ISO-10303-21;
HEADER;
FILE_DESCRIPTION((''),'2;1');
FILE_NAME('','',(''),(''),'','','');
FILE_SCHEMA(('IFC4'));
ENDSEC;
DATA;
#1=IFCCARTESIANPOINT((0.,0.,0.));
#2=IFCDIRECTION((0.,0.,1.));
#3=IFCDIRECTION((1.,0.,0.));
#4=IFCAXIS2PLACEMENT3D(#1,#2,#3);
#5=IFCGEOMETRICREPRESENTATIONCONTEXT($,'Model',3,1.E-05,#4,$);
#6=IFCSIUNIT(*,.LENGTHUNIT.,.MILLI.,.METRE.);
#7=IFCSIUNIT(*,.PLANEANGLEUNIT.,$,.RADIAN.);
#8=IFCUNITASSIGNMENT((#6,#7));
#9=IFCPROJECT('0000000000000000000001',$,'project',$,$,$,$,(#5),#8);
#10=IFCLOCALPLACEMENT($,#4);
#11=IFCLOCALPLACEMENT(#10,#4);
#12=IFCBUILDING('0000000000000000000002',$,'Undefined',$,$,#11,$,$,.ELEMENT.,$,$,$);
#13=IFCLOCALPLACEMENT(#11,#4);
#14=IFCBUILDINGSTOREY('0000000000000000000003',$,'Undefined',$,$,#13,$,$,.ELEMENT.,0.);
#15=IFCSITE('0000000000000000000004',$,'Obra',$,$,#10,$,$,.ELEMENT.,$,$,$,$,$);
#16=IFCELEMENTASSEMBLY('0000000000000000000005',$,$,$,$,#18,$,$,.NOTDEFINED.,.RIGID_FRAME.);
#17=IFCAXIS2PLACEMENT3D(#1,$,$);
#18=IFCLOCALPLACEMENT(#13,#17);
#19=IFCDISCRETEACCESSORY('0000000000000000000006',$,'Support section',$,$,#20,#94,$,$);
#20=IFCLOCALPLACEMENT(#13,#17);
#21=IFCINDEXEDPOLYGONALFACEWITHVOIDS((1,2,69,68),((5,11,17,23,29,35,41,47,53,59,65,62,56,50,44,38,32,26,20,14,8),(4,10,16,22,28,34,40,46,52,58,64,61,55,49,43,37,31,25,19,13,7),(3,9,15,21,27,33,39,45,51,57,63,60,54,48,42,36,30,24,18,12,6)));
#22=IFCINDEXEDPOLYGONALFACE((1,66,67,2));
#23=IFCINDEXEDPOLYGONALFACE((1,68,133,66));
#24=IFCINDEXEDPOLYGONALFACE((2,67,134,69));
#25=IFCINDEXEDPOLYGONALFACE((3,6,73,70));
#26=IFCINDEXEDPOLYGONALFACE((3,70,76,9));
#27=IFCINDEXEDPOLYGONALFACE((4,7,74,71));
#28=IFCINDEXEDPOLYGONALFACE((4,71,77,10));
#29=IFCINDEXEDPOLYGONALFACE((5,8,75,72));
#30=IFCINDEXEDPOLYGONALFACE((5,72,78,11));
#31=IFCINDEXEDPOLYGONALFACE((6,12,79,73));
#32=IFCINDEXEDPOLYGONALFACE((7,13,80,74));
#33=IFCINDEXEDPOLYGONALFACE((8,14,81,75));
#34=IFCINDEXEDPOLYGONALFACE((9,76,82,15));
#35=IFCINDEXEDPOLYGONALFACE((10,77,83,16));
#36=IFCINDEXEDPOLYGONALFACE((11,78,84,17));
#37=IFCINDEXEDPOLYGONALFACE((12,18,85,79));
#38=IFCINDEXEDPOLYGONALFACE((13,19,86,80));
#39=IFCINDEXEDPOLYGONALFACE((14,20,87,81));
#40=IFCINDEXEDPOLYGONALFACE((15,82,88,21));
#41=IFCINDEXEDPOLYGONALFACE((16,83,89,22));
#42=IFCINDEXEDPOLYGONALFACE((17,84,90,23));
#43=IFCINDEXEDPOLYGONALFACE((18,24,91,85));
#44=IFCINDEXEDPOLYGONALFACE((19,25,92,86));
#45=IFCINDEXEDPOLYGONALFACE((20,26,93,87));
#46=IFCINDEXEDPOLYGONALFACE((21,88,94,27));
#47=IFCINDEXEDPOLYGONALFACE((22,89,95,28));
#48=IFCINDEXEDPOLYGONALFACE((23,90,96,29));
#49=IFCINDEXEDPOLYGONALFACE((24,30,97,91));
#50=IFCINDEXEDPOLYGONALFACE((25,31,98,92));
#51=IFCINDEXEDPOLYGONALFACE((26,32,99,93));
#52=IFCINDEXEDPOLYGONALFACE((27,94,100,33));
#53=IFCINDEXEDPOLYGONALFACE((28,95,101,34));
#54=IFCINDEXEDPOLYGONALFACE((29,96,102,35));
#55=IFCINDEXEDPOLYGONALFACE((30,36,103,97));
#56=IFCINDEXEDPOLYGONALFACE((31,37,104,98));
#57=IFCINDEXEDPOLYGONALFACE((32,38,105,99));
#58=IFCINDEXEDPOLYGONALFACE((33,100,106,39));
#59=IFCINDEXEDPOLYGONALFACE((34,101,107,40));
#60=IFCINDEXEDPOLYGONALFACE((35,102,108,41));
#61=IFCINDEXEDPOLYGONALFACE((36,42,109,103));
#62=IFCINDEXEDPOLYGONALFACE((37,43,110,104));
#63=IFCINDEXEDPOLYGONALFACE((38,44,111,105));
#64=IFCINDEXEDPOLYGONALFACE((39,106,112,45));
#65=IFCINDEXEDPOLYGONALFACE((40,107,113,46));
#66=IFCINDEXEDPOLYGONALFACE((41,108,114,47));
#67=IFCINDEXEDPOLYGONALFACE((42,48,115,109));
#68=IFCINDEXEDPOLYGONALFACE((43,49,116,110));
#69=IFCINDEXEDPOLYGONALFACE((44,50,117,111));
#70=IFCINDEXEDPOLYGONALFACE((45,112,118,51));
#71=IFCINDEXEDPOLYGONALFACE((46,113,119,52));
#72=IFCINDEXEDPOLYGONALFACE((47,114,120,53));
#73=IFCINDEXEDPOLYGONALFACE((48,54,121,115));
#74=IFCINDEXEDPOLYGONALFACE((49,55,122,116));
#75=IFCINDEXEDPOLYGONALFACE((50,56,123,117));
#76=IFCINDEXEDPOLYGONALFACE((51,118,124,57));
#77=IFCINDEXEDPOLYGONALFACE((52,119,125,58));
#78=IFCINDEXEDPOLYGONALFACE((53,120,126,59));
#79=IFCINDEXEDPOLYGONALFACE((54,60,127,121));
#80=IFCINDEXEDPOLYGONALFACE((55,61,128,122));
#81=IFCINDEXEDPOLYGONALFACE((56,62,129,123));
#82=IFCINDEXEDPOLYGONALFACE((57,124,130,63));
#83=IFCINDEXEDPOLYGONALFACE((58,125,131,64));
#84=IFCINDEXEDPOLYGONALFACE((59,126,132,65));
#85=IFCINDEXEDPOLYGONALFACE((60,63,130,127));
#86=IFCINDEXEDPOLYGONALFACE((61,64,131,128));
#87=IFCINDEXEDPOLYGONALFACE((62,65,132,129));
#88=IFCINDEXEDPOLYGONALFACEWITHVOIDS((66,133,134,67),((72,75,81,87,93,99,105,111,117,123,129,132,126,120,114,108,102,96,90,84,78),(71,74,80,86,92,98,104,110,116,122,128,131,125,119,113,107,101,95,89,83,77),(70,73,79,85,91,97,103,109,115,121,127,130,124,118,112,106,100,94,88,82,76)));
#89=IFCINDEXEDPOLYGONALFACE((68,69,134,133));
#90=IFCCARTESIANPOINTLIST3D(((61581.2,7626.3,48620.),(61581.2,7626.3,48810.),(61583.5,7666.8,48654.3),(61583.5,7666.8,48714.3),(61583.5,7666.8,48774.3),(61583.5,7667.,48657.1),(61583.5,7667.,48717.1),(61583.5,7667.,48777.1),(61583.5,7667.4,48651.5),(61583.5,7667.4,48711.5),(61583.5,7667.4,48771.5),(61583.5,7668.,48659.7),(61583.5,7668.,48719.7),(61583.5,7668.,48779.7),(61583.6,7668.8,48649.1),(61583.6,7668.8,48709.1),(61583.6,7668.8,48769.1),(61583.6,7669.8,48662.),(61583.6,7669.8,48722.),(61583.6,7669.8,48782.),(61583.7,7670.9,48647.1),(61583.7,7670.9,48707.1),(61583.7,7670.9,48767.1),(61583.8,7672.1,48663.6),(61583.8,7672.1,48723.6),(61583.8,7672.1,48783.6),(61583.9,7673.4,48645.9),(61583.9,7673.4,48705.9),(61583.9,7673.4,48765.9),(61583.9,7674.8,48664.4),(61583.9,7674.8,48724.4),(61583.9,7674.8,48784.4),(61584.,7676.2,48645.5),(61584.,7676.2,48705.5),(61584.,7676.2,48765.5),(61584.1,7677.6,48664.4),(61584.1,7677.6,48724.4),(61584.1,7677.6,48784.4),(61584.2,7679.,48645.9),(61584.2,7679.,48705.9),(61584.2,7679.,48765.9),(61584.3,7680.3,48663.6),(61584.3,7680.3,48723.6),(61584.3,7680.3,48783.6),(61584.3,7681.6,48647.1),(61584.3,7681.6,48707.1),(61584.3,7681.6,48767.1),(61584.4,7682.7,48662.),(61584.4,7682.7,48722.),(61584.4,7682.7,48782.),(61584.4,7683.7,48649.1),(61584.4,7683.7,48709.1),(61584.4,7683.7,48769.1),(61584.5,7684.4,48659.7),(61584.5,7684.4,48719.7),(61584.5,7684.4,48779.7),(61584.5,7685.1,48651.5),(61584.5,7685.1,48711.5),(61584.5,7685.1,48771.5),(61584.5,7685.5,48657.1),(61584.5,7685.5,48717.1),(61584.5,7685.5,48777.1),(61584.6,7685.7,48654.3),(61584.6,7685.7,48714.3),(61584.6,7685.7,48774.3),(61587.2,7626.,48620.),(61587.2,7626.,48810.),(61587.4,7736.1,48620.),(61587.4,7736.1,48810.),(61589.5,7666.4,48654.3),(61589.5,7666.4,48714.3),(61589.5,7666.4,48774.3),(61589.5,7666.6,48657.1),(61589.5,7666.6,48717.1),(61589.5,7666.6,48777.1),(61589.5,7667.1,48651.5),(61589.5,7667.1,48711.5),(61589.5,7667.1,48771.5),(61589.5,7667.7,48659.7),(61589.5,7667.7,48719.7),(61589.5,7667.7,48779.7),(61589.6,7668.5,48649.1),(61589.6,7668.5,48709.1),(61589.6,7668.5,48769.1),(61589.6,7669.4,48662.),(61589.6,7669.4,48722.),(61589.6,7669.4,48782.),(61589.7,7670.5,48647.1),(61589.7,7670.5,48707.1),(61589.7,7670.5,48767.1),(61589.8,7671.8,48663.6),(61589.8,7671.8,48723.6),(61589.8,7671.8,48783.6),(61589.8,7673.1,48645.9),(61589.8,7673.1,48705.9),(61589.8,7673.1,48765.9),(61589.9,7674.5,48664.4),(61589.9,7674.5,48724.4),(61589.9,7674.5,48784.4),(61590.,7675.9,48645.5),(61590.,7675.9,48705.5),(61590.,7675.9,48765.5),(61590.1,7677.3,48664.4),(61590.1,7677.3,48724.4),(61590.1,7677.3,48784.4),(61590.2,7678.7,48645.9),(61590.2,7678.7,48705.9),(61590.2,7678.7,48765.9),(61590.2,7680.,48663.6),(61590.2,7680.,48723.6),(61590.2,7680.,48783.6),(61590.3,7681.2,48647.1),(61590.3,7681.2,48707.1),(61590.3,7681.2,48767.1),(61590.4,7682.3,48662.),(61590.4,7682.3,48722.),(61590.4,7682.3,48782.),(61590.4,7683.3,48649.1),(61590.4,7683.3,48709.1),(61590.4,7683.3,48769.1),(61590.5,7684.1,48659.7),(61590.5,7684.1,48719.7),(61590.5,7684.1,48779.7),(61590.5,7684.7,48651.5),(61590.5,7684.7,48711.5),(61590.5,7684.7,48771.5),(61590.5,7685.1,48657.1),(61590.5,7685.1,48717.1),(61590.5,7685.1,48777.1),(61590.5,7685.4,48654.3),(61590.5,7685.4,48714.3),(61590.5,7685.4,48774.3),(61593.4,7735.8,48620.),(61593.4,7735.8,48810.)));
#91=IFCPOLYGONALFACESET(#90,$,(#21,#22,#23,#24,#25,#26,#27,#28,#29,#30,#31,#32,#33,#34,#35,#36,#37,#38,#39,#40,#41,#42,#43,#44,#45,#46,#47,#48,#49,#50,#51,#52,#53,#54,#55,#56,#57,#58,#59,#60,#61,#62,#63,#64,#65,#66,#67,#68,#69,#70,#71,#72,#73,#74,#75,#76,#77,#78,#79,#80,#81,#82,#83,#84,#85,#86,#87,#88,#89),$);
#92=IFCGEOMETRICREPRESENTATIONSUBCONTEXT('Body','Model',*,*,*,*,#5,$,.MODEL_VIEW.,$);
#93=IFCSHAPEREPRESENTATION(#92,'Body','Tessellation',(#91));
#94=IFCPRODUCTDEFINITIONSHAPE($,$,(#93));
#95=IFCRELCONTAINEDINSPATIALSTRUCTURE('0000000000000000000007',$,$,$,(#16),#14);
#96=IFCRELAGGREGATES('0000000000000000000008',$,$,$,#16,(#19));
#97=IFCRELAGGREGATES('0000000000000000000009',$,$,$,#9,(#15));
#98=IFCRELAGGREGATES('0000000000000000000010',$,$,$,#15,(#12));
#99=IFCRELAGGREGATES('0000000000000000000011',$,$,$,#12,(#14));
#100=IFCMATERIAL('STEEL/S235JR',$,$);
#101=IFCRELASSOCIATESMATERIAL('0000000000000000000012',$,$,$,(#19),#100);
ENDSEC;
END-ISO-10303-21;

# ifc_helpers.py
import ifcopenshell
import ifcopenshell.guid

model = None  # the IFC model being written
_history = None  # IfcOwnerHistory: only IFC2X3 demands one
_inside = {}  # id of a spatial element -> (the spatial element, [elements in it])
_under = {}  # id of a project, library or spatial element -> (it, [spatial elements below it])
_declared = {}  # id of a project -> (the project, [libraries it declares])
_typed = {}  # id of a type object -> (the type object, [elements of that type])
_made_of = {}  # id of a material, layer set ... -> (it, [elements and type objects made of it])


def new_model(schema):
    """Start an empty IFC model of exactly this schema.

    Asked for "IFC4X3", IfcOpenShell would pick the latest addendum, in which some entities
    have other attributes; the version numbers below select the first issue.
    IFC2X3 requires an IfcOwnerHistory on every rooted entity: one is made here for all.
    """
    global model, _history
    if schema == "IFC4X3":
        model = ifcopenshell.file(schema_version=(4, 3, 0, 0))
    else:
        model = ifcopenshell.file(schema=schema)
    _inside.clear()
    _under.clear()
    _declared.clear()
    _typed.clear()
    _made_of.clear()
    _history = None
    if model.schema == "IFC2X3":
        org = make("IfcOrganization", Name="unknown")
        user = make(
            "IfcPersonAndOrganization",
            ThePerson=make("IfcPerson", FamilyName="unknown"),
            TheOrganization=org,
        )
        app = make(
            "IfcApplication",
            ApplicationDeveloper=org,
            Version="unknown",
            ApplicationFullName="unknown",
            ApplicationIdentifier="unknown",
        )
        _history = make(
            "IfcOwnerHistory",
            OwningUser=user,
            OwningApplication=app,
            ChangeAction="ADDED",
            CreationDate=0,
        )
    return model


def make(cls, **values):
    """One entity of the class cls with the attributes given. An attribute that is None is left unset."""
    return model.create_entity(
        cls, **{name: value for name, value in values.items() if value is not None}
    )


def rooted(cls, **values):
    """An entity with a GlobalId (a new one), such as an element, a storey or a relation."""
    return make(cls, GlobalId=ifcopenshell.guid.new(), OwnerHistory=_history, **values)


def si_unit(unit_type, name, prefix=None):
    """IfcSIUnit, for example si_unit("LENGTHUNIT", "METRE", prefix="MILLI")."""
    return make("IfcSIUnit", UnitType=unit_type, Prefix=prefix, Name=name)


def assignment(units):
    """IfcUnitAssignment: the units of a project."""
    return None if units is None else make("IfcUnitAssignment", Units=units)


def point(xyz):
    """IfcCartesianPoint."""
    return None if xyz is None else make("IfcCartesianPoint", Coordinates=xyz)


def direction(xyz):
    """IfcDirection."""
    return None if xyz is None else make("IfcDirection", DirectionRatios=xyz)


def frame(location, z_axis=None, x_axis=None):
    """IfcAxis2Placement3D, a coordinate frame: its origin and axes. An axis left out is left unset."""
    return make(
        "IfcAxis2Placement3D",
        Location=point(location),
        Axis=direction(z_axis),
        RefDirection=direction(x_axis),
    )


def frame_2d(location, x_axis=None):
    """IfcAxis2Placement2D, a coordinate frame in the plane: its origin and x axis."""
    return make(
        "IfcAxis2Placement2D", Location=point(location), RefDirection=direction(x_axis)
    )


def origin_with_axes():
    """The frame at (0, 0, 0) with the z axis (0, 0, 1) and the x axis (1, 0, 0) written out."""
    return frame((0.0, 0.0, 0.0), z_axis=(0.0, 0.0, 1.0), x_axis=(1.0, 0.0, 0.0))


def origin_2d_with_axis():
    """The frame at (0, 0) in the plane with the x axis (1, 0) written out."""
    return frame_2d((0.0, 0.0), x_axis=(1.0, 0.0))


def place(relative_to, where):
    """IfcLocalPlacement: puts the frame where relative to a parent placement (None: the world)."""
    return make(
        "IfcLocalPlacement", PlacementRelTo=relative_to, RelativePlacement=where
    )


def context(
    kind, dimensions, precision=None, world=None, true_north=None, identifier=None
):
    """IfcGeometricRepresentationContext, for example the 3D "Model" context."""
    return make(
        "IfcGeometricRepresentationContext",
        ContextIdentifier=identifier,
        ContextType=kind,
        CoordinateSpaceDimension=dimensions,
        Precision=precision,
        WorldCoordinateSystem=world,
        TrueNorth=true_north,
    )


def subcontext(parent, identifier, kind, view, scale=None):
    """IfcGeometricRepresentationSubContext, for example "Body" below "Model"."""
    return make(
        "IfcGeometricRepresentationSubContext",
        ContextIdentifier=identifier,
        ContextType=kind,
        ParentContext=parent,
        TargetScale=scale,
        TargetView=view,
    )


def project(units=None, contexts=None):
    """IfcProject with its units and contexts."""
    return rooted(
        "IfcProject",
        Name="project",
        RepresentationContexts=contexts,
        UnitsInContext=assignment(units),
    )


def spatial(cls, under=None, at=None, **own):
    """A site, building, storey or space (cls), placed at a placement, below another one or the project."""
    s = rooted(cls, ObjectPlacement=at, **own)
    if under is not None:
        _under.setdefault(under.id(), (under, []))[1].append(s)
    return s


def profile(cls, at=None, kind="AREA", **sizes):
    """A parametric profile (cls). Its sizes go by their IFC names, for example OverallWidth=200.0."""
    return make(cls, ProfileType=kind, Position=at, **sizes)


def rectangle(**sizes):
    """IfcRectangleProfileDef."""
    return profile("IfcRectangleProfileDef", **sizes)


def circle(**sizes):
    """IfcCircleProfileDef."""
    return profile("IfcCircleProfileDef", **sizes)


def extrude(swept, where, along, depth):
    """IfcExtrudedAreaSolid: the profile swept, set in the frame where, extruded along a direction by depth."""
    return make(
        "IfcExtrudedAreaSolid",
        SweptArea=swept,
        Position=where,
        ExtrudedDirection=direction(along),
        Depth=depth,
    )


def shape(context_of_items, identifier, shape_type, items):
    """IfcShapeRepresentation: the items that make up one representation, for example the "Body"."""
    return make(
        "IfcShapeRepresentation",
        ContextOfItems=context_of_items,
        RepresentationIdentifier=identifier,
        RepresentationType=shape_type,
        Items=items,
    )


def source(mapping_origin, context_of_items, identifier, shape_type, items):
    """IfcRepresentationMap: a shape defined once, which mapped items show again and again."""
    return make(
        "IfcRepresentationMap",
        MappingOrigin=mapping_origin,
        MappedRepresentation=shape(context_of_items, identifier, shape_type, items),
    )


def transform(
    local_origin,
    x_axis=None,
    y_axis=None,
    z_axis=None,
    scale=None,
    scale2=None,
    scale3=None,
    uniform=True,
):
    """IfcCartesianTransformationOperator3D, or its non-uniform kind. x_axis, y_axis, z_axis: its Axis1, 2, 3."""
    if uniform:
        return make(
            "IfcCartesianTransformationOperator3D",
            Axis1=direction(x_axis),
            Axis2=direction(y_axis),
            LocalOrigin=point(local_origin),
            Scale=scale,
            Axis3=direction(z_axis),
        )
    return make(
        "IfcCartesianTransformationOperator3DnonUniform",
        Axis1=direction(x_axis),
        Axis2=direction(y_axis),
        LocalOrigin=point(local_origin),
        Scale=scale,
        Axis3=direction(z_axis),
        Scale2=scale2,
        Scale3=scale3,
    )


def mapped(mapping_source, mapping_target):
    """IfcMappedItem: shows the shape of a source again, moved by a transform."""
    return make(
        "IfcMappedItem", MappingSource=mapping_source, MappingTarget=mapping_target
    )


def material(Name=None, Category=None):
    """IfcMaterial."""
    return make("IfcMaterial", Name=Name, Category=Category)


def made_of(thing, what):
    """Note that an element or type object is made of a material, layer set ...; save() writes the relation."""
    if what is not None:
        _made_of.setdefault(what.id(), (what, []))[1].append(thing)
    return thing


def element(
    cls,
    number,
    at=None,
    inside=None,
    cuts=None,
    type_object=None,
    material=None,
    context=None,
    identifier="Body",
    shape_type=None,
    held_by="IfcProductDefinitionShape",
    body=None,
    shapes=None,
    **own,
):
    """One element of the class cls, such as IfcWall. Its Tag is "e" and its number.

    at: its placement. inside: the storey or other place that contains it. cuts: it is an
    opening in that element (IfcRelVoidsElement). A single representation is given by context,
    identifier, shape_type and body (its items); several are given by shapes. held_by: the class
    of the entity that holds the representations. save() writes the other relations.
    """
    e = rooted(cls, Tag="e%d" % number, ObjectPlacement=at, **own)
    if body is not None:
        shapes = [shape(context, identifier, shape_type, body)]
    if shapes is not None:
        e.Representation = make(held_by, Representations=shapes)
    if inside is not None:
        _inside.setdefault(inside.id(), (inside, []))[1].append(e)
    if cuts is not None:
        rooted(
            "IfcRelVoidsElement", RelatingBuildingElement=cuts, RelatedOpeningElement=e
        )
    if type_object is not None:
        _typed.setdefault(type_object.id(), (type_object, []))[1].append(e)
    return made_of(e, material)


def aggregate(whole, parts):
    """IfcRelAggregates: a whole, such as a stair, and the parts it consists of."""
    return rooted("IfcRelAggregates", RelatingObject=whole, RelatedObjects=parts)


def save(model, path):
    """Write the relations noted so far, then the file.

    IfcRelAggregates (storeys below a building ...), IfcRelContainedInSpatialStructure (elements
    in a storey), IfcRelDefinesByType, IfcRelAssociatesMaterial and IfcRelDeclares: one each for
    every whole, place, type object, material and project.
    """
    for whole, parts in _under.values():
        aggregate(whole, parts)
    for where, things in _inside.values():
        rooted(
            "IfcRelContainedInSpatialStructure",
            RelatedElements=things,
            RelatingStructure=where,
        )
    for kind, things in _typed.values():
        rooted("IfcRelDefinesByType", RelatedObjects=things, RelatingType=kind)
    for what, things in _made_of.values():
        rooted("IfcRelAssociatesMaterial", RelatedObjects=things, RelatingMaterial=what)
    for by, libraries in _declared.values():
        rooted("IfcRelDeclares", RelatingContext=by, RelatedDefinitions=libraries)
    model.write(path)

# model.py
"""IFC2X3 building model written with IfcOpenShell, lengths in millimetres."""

from ifc_helpers import new_model, si_unit, frame, origin_with_axes, origin_2d_with_axis, place, context, subcontext, project, spatial, rectangle, circle, extrude, source, transform, mapped, material, element, aggregate, save


model = new_model("IFC2X3")

# Units and contexts
model_context = context("Model", 3, precision=1e-05, world=origin_with_axes())
body_context = subcontext(model_context, "Body", "Model", "MODEL_VIEW")
ifc_project = project(units=[si_unit("LENGTHUNIT", "METRE", prefix="MILLI"), si_unit("PLANEANGLEUNIT", "RADIAN")], contexts=[model_context])

# Site, building, storey
site_placement = place(None, origin_with_axes())
site = spatial("IfcSite", under=ifc_project, at=site_placement, Name="Obra", CompositionType="ELEMENT")
building_placement = place(site_placement, origin_with_axes())
building = spatial("IfcBuilding", under=site, at=building_placement, Name="Undefined", CompositionType="ELEMENT")
storey_placement = place(building_placement, origin_with_axes())
storey = spatial("IfcBuildingStorey", under=building, at=storey_placement, Name="Undefined", CompositionType="ELEMENT", Elevation=0.0)

# Element assembly
ifc_material_1 = material(Name="STEEL/S235JR")
assembly_1_placement = place(storey_placement, origin_with_axes())
assembly_1 = element("IfcElementAssembly", 1, at=assembly_1_placement, inside=storey, AssemblyPlace="NOTDEFINED", PredefinedType="RIGID_FRAME")

# Discrete accessory, opening
shared_shape_1 = source(origin_with_axes(), body_context, "Body", "SweptSolid", [
    extrude(circle(Radius=9.5, at=origin_2d_with_axis()), frame((0.0, -9.2, 0.0), z_axis=(0.0, 1.0, 0.0), x_axis=(1.0, 0.0, 0.0)), (0.0, 0.0, 1.0), 6.2),
])
discrete_accessory_1_placement = place(assembly_1_placement, frame((61587.3, 7681.1, 48620.0), z_axis=(0.0, 0.0, 1.0), x_axis=(0.05711, 0.998368, 0.0)))
discrete_accessory_1 = element("IfcDiscreteAccessory", 2, at=discrete_accessory_1_placement, material=ifc_material_1, Name="Support section", context=body_context, shape_type="SweptSolid", body=[
    extrude(rectangle(XDim=6.0, YDim=110.0, at=origin_2d_with_axis()), frame((0.0, 0.0, 190.0), z_axis=(0.0, 0.0, -1.0), x_axis=(0.0, 1.0, 0.0)), (0.0, 0.0, 1.0), 190.0),
])
opening_1_placement = place(assembly_1_placement, frame((61596.0, 7725.6, 48835.0), z_axis=(-0.05711, -0.998368, 0.0), x_axis=(0.0, 0.0, -1.0)))
element("IfcOpeningElement", 3, at=opening_1_placement, cuts=discrete_accessory_1, ObjectType="Opening", context=body_context, shape_type="MappedRepresentation", body=[
    mapped(shared_shape_1, transform((60.0, 0.0, 50.0))),
    mapped(shared_shape_1, transform((120.0, 0.0, 50.0))),
    mapped(shared_shape_1, transform((180.0, 0.0, 50.0))),
])
aggregate(assembly_1, [discrete_accessory_1])

save(model, "model.ifc")
